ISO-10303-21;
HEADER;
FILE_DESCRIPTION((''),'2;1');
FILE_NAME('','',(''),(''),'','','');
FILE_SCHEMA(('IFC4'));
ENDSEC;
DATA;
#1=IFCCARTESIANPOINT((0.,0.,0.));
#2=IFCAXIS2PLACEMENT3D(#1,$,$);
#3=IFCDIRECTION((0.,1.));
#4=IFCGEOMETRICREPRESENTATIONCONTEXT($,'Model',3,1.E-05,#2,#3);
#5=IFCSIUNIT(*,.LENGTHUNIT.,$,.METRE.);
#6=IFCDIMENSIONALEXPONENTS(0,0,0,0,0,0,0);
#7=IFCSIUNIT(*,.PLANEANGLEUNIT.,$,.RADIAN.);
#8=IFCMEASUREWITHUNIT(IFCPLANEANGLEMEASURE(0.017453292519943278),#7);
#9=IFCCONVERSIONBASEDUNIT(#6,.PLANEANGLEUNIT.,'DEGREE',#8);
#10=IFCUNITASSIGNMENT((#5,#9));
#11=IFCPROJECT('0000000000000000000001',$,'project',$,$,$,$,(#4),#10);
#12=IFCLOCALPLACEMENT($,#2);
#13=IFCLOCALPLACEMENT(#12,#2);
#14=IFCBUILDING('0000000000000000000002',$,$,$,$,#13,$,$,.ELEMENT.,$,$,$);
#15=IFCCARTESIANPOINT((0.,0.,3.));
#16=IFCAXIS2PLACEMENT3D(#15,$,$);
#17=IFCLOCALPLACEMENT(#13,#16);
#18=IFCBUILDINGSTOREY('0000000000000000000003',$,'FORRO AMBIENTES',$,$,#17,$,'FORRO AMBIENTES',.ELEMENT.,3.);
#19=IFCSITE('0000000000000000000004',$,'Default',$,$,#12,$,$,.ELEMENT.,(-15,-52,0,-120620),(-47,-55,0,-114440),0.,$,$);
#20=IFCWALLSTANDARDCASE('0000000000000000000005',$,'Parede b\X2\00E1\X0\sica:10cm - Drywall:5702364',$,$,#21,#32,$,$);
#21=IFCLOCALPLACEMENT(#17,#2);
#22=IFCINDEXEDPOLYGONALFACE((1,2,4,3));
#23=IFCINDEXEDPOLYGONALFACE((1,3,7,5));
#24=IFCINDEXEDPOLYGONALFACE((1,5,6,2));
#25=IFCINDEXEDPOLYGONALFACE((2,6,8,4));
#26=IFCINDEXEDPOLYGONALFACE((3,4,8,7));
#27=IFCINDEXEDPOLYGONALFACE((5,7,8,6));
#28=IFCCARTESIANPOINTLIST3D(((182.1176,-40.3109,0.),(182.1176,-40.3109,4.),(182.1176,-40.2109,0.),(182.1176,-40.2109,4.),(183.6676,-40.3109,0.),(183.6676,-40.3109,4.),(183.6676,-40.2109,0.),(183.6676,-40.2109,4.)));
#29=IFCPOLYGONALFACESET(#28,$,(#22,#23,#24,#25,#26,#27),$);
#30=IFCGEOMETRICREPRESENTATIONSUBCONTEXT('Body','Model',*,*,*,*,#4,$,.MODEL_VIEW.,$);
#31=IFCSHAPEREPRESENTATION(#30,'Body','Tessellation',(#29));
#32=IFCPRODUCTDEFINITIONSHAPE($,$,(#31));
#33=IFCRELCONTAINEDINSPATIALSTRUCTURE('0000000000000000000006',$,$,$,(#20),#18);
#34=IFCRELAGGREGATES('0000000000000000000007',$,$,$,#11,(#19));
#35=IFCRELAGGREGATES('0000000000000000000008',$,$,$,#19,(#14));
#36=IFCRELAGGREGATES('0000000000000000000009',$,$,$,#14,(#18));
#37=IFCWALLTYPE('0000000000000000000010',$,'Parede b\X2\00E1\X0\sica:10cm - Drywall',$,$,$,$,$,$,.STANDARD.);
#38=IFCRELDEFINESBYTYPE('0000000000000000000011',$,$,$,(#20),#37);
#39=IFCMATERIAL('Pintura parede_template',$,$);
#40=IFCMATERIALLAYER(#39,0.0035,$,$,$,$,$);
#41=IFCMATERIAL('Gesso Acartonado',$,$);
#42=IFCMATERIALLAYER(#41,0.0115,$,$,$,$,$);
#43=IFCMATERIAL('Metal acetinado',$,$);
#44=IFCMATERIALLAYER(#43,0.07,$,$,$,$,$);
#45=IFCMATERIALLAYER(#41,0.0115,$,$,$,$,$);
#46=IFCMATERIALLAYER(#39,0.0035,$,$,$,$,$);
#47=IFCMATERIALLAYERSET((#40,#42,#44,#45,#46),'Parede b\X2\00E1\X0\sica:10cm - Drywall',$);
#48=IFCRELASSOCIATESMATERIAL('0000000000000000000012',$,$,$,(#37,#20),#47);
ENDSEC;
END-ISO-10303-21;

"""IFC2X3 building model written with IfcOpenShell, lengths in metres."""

from ifc_helpers import new_model, entity, si_unit, converted_unit, direction, frame, frame_2d, origin, place, context, subcontext, project, spatial, rectangle, extrude, material, layer, layer_set, layer_usage, type_object, element, save


model = new_model("IFC2X3")

# Units and contexts
model_context = context("Model", 3, precision=1e-05, world=origin(), true_north=direction((0.0, 1.0)))
body_context = subcontext(model_context, "Body", "Model", "MODEL_VIEW")
ifc_project = project(units=[si_unit("LENGTHUNIT", "METRE"), converted_unit("PLANEANGLEUNIT", "DEGREE", entity("IfcPlaneAngleMeasure", 0.017453292519943278), si_unit("PLANEANGLEUNIT", "RADIAN"), dimensions=[0, 0, 0, 0, 0, 0, 0])], contexts=[model_context])

# Site, building, storey
site_placement = place(None, origin())
site = spatial("IfcSite", under=ifc_project, at=site_placement, Name="Default", CompositionType="ELEMENT", RefLatitude=(-15, -52, 0, -120620), RefLongitude=(-47, -55, 0, -114440), RefElevation=0.0)
building_placement = place(site_placement, origin())
building = spatial("IfcBuilding", under=site, at=building_placement, CompositionType="ELEMENT")
storey_placement = place(building_placement, frame((0.0, 0.0, 3.0)))
storey = spatial("IfcBuildingStorey", under=building, at=storey_placement, Name="FORRO AMBIENTES", LongName="FORRO AMBIENTES", CompositionType="ELEMENT", Elevation=3.0)

# Wall
ifc_material_1 = material(Name="Pintura parede_template")
ifc_layer_1 = layer(ifc_material_1, 0.0035)
ifc_material_2 = material(Name="Gesso Acartonado")
ifc_layer_2 = layer(ifc_material_2, 0.0115)
ifc_material_3 = material(Name="Metal acetinado")
ifc_layer_3 = layer(ifc_material_3, 0.07)
ifc_layer_4 = layer(ifc_material_2, 0.0115)
ifc_layer_5 = layer(ifc_material_1, 0.0035)
ifc_layer_set_1 = layer_set([ifc_layer_1, ifc_layer_2, ifc_layer_3, ifc_layer_4, ifc_layer_5], Name="Parede básica:10cm - Drywall")
ifc_layer_usage_1 = layer_usage(ifc_layer_set_1, "AXIS2", "NEGATIVE", 0.05)
wall_type = type_object("IfcWallType", Name="Parede básica:10cm - Drywall", PredefinedType="STANDARD", material=ifc_layer_set_1)
wall_placement = place(storey_placement, frame((183.6676, -40.2609, 0.0), z_axis=(0.0, 0.0, 1.0), x_axis=(-1.0, 0.0, 0.0)))
element("IfcWallStandardCase", 1, at=wall_placement, inside=storey, type_object=wall_type, material=ifc_layer_usage_1, Name="Parede básica:10cm - Drywall:5702364", context=body_context, shape_type="SweptSolid", body=[
    extrude(rectangle(XDim=1.55, YDim=0.1, at=frame_2d((0.775, 0.0), x_axis=(-1.0, 0.0))), origin(), (0.0, 0.0, 1.0), 4.0),
])

save(model, "model.ifc")
